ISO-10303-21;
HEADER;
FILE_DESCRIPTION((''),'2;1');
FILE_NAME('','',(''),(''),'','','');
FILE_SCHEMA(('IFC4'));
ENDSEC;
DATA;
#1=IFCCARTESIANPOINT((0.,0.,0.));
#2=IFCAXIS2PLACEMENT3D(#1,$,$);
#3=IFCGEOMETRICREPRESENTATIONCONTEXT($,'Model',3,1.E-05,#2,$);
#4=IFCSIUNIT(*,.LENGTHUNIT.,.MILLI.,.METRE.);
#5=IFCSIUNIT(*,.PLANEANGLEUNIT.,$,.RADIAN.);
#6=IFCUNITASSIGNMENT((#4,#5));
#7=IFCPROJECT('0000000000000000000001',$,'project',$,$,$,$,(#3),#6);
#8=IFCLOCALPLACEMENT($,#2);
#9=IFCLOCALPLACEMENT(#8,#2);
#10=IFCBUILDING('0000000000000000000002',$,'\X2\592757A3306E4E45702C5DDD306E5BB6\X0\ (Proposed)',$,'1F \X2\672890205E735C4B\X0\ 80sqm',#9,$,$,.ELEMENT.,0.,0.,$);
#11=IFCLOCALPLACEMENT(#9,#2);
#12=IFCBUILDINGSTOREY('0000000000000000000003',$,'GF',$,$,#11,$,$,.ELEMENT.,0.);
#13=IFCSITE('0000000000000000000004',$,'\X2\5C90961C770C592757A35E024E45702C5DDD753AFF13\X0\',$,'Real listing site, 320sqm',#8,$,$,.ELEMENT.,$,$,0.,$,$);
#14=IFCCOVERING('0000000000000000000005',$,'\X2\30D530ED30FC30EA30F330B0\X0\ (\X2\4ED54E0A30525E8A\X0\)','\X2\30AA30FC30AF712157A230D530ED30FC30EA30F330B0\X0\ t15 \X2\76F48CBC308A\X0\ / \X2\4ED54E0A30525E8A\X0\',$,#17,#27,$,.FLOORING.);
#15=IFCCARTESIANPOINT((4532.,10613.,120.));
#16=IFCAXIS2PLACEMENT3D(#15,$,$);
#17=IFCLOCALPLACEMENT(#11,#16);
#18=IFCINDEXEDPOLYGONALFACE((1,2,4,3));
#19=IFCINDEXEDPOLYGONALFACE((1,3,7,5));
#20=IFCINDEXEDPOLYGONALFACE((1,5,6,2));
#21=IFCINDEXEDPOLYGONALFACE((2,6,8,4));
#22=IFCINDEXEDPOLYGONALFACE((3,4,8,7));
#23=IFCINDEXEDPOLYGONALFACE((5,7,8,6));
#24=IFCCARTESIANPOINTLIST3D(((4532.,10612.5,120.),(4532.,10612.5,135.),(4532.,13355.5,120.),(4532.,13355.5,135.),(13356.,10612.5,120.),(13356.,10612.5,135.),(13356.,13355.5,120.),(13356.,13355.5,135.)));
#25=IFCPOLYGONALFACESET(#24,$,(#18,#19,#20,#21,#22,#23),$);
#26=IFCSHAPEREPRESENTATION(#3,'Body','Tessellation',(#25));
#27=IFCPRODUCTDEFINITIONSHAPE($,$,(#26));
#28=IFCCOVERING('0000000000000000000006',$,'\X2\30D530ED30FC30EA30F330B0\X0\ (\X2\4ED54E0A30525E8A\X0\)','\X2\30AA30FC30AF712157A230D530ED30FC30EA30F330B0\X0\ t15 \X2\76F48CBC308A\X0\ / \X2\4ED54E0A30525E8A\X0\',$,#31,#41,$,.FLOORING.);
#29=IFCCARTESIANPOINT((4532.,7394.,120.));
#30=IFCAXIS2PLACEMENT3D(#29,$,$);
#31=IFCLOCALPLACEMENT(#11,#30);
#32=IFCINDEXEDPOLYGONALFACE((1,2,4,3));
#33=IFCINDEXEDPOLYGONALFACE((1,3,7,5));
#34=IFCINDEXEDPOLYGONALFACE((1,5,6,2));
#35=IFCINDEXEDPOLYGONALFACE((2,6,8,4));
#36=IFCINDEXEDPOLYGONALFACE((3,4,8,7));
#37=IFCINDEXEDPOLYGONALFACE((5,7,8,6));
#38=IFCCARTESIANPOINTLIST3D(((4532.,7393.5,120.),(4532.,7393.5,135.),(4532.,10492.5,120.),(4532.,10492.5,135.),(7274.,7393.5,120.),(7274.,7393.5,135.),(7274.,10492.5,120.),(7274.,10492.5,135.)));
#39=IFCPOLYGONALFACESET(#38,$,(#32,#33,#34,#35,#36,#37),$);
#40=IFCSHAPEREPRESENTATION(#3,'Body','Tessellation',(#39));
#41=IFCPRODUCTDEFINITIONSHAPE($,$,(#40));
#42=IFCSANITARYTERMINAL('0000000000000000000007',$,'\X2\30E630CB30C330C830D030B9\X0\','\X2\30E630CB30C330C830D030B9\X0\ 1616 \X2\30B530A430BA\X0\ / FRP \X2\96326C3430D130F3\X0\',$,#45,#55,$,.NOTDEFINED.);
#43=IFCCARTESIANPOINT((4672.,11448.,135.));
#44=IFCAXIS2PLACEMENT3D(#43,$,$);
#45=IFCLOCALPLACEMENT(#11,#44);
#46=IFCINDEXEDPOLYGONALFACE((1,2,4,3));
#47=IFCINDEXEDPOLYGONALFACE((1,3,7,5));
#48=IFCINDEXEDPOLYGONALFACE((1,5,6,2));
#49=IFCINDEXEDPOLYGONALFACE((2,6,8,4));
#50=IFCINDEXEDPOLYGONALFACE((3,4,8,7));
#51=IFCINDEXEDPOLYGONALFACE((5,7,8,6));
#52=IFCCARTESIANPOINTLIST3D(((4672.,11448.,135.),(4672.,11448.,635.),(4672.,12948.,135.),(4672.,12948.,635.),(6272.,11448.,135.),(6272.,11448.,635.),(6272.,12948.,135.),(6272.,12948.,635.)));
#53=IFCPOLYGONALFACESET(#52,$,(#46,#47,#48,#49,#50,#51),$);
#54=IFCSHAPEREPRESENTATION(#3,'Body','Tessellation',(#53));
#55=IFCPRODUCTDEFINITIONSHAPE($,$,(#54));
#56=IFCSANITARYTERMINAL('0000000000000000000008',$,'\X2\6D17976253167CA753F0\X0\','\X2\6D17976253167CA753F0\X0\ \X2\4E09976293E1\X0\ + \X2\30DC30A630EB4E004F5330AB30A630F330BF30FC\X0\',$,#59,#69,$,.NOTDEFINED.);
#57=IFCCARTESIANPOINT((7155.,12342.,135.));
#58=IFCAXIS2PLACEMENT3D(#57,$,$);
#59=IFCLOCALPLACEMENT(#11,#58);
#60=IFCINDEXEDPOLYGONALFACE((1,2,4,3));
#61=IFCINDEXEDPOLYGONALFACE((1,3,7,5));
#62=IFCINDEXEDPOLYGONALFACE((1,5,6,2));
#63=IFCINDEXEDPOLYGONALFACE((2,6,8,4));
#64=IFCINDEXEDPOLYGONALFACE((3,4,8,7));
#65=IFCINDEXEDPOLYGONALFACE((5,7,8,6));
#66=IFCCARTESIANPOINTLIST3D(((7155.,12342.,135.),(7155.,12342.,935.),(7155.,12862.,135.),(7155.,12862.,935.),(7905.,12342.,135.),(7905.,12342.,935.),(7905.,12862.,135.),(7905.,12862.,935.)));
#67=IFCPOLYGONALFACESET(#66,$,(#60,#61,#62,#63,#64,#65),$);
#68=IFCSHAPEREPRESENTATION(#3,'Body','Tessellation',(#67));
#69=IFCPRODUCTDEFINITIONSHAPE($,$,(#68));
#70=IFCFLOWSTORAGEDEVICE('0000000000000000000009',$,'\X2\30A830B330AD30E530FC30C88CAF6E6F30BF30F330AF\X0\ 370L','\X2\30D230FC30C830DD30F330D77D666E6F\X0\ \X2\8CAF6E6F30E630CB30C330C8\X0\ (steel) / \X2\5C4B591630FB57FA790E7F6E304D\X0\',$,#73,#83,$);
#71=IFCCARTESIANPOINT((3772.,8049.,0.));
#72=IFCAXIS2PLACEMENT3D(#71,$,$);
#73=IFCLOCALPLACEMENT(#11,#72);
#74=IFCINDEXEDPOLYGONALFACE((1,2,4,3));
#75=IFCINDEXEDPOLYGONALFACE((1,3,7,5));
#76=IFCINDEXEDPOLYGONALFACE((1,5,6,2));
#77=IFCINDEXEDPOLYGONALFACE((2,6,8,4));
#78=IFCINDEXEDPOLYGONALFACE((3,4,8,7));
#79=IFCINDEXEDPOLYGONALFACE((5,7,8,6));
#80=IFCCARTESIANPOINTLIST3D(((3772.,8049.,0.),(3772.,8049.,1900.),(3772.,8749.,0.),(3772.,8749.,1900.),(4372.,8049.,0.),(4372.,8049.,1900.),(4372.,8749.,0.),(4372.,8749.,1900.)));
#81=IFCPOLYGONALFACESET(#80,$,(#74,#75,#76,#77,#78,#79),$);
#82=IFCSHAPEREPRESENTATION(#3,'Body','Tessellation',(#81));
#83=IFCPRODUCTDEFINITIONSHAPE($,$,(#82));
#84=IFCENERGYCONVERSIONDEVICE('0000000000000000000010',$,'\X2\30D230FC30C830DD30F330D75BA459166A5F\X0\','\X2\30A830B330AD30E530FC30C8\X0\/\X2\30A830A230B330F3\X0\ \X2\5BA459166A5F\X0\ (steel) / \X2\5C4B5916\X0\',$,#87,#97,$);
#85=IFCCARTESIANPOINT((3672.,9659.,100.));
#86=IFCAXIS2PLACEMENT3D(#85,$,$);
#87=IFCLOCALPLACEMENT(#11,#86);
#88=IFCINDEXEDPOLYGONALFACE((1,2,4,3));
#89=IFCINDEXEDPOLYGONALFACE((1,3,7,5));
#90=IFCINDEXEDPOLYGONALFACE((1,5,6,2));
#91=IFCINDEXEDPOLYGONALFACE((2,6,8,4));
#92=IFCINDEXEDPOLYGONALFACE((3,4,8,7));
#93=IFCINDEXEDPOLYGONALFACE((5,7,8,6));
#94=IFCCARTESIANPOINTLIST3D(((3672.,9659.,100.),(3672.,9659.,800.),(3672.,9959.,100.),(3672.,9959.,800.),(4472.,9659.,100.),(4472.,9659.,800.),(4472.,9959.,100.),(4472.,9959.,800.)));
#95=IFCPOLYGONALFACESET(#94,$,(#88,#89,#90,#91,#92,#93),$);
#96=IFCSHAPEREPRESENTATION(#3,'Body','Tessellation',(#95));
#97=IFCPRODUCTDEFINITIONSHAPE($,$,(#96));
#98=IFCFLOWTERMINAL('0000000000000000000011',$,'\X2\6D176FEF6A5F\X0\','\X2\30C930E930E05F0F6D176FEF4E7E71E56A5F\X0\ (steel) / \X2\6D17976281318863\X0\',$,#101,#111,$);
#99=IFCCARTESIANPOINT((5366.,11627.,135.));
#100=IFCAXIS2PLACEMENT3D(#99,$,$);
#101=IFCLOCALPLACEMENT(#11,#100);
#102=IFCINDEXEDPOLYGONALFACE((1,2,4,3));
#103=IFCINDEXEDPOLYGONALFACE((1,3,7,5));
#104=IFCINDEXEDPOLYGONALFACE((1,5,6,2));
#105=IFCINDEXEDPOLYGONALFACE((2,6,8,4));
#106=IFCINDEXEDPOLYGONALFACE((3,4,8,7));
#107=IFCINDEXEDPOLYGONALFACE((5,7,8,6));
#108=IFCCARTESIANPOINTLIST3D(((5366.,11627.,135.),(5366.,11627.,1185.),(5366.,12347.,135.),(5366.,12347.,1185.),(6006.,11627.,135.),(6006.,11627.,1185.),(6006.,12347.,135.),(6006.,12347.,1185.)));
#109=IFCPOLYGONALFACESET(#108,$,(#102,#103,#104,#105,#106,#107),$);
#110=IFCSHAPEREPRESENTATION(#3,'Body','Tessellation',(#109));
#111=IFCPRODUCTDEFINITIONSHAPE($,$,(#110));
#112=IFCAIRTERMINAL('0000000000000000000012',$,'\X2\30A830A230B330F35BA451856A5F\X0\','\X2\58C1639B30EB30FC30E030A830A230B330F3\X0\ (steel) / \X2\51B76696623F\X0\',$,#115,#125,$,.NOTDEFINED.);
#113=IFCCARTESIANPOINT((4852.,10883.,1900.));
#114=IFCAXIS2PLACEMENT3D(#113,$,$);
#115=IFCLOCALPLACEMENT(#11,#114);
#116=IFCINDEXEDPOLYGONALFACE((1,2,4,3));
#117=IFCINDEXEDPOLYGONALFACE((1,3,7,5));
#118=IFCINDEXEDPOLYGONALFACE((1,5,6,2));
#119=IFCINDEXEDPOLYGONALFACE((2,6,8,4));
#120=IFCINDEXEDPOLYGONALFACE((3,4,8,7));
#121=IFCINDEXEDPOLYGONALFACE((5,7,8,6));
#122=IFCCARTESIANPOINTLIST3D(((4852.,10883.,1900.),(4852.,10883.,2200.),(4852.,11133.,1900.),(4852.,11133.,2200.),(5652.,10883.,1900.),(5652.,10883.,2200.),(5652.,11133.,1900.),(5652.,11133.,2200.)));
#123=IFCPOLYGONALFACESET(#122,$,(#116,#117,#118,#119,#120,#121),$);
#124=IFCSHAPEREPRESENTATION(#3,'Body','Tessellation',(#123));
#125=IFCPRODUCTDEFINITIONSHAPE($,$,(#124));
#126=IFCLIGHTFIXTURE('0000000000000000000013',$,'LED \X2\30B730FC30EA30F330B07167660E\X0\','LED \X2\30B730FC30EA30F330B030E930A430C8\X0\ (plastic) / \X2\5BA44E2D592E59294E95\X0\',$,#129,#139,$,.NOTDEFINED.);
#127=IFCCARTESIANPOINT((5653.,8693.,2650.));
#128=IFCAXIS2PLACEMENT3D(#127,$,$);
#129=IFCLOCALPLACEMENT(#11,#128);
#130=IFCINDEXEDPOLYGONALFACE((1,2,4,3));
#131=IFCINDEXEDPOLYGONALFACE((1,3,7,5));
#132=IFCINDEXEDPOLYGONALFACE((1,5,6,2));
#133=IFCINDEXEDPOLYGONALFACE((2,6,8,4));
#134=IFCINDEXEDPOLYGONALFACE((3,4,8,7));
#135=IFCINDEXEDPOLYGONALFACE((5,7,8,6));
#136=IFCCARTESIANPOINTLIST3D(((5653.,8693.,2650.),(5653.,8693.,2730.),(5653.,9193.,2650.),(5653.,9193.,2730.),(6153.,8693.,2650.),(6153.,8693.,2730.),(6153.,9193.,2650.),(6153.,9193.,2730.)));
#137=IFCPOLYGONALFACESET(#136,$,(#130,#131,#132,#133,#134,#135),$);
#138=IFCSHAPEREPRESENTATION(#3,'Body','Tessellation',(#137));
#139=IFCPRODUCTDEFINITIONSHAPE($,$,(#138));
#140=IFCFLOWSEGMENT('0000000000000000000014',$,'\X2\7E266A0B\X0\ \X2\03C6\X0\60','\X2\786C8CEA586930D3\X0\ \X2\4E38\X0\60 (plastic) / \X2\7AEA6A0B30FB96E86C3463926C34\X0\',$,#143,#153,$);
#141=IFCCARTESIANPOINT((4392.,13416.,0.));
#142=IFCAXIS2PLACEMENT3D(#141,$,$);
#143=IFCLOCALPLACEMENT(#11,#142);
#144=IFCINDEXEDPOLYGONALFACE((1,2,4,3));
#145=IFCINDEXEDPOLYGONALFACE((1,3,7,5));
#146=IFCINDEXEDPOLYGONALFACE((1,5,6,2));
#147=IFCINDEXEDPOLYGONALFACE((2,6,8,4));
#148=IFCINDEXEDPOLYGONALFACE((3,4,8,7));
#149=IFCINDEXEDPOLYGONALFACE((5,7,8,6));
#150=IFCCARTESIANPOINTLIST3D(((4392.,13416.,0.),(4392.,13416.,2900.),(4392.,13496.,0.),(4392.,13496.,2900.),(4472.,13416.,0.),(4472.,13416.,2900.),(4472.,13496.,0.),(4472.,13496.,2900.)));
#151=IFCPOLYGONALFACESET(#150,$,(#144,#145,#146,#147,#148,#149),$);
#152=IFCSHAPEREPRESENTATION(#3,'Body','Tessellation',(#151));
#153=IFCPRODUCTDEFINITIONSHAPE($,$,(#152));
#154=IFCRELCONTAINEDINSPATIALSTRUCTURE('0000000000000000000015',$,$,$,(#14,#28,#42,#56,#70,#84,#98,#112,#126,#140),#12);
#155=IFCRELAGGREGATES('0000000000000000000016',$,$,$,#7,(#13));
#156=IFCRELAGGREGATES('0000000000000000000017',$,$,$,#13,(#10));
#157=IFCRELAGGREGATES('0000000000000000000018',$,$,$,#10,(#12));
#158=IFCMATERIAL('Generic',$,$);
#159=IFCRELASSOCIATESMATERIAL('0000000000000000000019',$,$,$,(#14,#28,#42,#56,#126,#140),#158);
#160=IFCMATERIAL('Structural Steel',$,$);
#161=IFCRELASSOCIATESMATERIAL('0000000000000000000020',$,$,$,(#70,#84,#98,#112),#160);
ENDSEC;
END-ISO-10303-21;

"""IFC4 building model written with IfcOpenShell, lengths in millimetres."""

from ifc_helpers import new_model, si_unit, frame, frame_2d, origin, place, context, project, spatial, rectangle, extrude, material, element, save


model = new_model("IFC4")

# Units and contexts
model_context = context("Model", 3, precision=1e-05, world=origin())
ifc_project = project(units=[si_unit("LENGTHUNIT", "METRE", prefix="MILLI"), si_unit("PLANEANGLEUNIT", "RADIAN")], contexts=[model_context])

# Site, building, storey
site_placement = place(None, origin())
site = spatial("IfcSite", under=ifc_project, at=site_placement, Name="岐阜県大垣市久瀬川町３", ObjectType="Real listing site, 320sqm", CompositionType="ELEMENT", RefElevation=0.0)
building_placement = place(site_placement, origin())
building = spatial("IfcBuilding", under=site, at=building_placement, Name="大垣の久瀬川の家 (Proposed)", ObjectType="1F 木造平屋 80sqm", CompositionType="ELEMENT", ElevationOfRefHeight=0.0, ElevationOfTerrain=0.0)
storey_placement = place(building_placement, origin())
storey = spatial("IfcBuildingStorey", under=building, at=storey_placement, Name="GF", CompositionType="ELEMENT", Elevation=0.0)

# Shared definitions
ifc_material_1 = material(Name="Structural Steel")

# Coverings
ifc_material_2 = material(Name="Generic")
covering_1_placement = place(storey_placement, frame((4532.0, 10613.0, 120.0)))
element("IfcCovering", 1, at=covering_1_placement, inside=storey, material=ifc_material_2, Name="フローリング (仕上げ床)", Description="オーク無垢フローリング t15 直貼り / 仕上げ床", PredefinedType="FLOORING", context=model_context, shape_type="SweptSolid", body=[
    extrude(rectangle(XDim=8824.0, YDim=2743.0, at=frame_2d((4412.0, 1371.0))), frame((4532.0, 10613.0, 120.0)), (0.0, 0.0, 1.0), 15.0),
])
covering_2_placement = place(storey_placement, frame((4532.0, 7394.0, 120.0)))
element("IfcCovering", 2, at=covering_2_placement, inside=storey, material=ifc_material_2, Name="フローリング (仕上げ床)", Description="オーク無垢フローリング t15 直貼り / 仕上げ床", PredefinedType="FLOORING", context=model_context, shape_type="SweptSolid", body=[
    extrude(rectangle(XDim=2742.0, YDim=3099.0, at=frame_2d((1371.0, 1549.0))), frame((4532.0, 7394.0, 120.0)), (0.0, 0.0, 1.0), 15.0),
])

# Sanitary terminals
sanitary_terminal_1_placement = place(storey_placement, frame((4672.0, 11448.0, 135.0)))
element("IfcSanitaryTerminal", 3, at=sanitary_terminal_1_placement, inside=storey, material=ifc_material_2, Name="ユニットバス", Description="ユニットバス 1616 サイズ / FRP 防水パン", PredefinedType="NOTDEFINED", context=model_context, shape_type="SweptSolid", body=[
    extrude(rectangle(XDim=1600.0, YDim=1500.0, at=frame_2d((800.0, 750.0))), frame((4672.0, 11448.0, 135.0)), (0.0, 0.0, 1.0), 500.0),
])
sanitary_terminal_2_placement = place(storey_placement, frame((7155.0, 12342.0, 135.0)))
element("IfcSanitaryTerminal", 4, at=sanitary_terminal_2_placement, inside=storey, material=ifc_material_2, Name="洗面化粧台", Description="洗面化粧台 三面鏡 + ボウル一体カウンター", PredefinedType="NOTDEFINED", context=model_context, shape_type="SweptSolid", body=[
    extrude(rectangle(XDim=750.0, YDim=520.0, at=frame_2d((375.0, 260.0))), frame((7155.0, 12342.0, 135.0)), (0.0, 0.0, 1.0), 800.0),
])

# Flow storage device
flow_storage_device_placement = place(storey_placement, frame((3772.0, 8049.0, 0.0)))
element("IfcFlowStorageDevice", 5, at=flow_storage_device_placement, inside=storey, material=ifc_material_1, Name="エコキュート貯湯タンク 370L", Description="ヒートポンプ給湯 貯湯ユニット (steel) / 屋外・基礎置き", context=model_context, shape_type="SweptSolid", body=[
    extrude(rectangle(XDim=600.0, YDim=700.0, at=frame_2d((300.0, 350.0))), frame((3772.0, 8049.0, 0.0)), (0.0, 0.0, 1.0), 1900.0),
])

# Energy conversion device
energy_conversion_device_placement = place(storey_placement, frame((3672.0, 9659.0, 100.0)))
element("IfcEnergyConversionDevice", 6, at=energy_conversion_device_placement, inside=storey, material=ifc_material_1, Name="ヒートポンプ室外機", Description="エコキュート/エアコン 室外機 (steel) / 屋外", context=model_context, shape_type="SweptSolid", body=[
    extrude(rectangle(XDim=800.0, YDim=300.0, at=frame_2d((400.0, 150.0))), frame((3672.0, 9659.0, 100.0)), (0.0, 0.0, 1.0), 700.0),
])

# Flow terminal
flow_terminal_placement = place(storey_placement, frame((5366.0, 11627.0, 135.0)))
element("IfcFlowTerminal", 7, at=flow_terminal_placement, inside=storey, material=ifc_material_1, Name="洗濯機", Description="ドラム式洗濯乾燥機 (steel) / 洗面脱衣", context=model_context, shape_type="SweptSolid", body=[
    extrude(rectangle(XDim=640.0, YDim=720.0, at=frame_2d((320.0, 360.0))), frame((5366.0, 11627.0, 135.0)), (0.0, 0.0, 1.0), 1050.0),
])

# Air terminal
air_terminal_placement = place(storey_placement, frame((4852.0, 10883.0, 1900.0)))
element("IfcAirTerminal", 8, at=air_terminal_placement, inside=storey, material=ifc_material_1, Name="エアコン室内機", Description="壁掛ルームエアコン (steel) / 冷暖房", PredefinedType="NOTDEFINED", context=model_context, shape_type="SweptSolid", body=[
    extrude(rectangle(XDim=800.0, YDim=250.0, at=frame_2d((400.0, 125.0))), frame((4852.0, 10883.0, 1900.0)), (0.0, 0.0, 1.0), 300.0),
])

# Light fixture
light_fixture_placement = place(storey_placement, frame((5653.0, 8693.0, 2650.0)))
element("IfcLightFixture", 9, at=light_fixture_placement, inside=storey, material=ifc_material_2, Name="LED シーリング照明", Description="LED シーリングライト (plastic) / 室中央天井", PredefinedType="NOTDEFINED", context=model_context, shape_type="SweptSolid", body=[
    extrude(rectangle(XDim=500.0, YDim=500.0, at=frame_2d((250.0, 250.0))), frame((5653.0, 8693.0, 2650.0)), (0.0, 0.0, 1.0), 80.0),
])

# Flow segment
flow_segment_1_placement = place(storey_placement, frame((4392.0, 13416.0, 0.0)))
element("IfcFlowSegment", 10, at=flow_segment_1_placement, inside=storey, material=ifc_material_2, Name="縦樋 φ60", Description="硬質塩ビ 丸60 (plastic) / 竪樋・雨水排水", context=model_context, shape_type="SweptSolid", body=[
    extrude(rectangle(XDim=80.0, YDim=80.0, at=frame_2d((40.0, 40.0))), frame((4392.0, 13416.0, 0.0)), (0.0, 0.0, 1.0), 2900.0),
])

save(model, "model.ifc")
